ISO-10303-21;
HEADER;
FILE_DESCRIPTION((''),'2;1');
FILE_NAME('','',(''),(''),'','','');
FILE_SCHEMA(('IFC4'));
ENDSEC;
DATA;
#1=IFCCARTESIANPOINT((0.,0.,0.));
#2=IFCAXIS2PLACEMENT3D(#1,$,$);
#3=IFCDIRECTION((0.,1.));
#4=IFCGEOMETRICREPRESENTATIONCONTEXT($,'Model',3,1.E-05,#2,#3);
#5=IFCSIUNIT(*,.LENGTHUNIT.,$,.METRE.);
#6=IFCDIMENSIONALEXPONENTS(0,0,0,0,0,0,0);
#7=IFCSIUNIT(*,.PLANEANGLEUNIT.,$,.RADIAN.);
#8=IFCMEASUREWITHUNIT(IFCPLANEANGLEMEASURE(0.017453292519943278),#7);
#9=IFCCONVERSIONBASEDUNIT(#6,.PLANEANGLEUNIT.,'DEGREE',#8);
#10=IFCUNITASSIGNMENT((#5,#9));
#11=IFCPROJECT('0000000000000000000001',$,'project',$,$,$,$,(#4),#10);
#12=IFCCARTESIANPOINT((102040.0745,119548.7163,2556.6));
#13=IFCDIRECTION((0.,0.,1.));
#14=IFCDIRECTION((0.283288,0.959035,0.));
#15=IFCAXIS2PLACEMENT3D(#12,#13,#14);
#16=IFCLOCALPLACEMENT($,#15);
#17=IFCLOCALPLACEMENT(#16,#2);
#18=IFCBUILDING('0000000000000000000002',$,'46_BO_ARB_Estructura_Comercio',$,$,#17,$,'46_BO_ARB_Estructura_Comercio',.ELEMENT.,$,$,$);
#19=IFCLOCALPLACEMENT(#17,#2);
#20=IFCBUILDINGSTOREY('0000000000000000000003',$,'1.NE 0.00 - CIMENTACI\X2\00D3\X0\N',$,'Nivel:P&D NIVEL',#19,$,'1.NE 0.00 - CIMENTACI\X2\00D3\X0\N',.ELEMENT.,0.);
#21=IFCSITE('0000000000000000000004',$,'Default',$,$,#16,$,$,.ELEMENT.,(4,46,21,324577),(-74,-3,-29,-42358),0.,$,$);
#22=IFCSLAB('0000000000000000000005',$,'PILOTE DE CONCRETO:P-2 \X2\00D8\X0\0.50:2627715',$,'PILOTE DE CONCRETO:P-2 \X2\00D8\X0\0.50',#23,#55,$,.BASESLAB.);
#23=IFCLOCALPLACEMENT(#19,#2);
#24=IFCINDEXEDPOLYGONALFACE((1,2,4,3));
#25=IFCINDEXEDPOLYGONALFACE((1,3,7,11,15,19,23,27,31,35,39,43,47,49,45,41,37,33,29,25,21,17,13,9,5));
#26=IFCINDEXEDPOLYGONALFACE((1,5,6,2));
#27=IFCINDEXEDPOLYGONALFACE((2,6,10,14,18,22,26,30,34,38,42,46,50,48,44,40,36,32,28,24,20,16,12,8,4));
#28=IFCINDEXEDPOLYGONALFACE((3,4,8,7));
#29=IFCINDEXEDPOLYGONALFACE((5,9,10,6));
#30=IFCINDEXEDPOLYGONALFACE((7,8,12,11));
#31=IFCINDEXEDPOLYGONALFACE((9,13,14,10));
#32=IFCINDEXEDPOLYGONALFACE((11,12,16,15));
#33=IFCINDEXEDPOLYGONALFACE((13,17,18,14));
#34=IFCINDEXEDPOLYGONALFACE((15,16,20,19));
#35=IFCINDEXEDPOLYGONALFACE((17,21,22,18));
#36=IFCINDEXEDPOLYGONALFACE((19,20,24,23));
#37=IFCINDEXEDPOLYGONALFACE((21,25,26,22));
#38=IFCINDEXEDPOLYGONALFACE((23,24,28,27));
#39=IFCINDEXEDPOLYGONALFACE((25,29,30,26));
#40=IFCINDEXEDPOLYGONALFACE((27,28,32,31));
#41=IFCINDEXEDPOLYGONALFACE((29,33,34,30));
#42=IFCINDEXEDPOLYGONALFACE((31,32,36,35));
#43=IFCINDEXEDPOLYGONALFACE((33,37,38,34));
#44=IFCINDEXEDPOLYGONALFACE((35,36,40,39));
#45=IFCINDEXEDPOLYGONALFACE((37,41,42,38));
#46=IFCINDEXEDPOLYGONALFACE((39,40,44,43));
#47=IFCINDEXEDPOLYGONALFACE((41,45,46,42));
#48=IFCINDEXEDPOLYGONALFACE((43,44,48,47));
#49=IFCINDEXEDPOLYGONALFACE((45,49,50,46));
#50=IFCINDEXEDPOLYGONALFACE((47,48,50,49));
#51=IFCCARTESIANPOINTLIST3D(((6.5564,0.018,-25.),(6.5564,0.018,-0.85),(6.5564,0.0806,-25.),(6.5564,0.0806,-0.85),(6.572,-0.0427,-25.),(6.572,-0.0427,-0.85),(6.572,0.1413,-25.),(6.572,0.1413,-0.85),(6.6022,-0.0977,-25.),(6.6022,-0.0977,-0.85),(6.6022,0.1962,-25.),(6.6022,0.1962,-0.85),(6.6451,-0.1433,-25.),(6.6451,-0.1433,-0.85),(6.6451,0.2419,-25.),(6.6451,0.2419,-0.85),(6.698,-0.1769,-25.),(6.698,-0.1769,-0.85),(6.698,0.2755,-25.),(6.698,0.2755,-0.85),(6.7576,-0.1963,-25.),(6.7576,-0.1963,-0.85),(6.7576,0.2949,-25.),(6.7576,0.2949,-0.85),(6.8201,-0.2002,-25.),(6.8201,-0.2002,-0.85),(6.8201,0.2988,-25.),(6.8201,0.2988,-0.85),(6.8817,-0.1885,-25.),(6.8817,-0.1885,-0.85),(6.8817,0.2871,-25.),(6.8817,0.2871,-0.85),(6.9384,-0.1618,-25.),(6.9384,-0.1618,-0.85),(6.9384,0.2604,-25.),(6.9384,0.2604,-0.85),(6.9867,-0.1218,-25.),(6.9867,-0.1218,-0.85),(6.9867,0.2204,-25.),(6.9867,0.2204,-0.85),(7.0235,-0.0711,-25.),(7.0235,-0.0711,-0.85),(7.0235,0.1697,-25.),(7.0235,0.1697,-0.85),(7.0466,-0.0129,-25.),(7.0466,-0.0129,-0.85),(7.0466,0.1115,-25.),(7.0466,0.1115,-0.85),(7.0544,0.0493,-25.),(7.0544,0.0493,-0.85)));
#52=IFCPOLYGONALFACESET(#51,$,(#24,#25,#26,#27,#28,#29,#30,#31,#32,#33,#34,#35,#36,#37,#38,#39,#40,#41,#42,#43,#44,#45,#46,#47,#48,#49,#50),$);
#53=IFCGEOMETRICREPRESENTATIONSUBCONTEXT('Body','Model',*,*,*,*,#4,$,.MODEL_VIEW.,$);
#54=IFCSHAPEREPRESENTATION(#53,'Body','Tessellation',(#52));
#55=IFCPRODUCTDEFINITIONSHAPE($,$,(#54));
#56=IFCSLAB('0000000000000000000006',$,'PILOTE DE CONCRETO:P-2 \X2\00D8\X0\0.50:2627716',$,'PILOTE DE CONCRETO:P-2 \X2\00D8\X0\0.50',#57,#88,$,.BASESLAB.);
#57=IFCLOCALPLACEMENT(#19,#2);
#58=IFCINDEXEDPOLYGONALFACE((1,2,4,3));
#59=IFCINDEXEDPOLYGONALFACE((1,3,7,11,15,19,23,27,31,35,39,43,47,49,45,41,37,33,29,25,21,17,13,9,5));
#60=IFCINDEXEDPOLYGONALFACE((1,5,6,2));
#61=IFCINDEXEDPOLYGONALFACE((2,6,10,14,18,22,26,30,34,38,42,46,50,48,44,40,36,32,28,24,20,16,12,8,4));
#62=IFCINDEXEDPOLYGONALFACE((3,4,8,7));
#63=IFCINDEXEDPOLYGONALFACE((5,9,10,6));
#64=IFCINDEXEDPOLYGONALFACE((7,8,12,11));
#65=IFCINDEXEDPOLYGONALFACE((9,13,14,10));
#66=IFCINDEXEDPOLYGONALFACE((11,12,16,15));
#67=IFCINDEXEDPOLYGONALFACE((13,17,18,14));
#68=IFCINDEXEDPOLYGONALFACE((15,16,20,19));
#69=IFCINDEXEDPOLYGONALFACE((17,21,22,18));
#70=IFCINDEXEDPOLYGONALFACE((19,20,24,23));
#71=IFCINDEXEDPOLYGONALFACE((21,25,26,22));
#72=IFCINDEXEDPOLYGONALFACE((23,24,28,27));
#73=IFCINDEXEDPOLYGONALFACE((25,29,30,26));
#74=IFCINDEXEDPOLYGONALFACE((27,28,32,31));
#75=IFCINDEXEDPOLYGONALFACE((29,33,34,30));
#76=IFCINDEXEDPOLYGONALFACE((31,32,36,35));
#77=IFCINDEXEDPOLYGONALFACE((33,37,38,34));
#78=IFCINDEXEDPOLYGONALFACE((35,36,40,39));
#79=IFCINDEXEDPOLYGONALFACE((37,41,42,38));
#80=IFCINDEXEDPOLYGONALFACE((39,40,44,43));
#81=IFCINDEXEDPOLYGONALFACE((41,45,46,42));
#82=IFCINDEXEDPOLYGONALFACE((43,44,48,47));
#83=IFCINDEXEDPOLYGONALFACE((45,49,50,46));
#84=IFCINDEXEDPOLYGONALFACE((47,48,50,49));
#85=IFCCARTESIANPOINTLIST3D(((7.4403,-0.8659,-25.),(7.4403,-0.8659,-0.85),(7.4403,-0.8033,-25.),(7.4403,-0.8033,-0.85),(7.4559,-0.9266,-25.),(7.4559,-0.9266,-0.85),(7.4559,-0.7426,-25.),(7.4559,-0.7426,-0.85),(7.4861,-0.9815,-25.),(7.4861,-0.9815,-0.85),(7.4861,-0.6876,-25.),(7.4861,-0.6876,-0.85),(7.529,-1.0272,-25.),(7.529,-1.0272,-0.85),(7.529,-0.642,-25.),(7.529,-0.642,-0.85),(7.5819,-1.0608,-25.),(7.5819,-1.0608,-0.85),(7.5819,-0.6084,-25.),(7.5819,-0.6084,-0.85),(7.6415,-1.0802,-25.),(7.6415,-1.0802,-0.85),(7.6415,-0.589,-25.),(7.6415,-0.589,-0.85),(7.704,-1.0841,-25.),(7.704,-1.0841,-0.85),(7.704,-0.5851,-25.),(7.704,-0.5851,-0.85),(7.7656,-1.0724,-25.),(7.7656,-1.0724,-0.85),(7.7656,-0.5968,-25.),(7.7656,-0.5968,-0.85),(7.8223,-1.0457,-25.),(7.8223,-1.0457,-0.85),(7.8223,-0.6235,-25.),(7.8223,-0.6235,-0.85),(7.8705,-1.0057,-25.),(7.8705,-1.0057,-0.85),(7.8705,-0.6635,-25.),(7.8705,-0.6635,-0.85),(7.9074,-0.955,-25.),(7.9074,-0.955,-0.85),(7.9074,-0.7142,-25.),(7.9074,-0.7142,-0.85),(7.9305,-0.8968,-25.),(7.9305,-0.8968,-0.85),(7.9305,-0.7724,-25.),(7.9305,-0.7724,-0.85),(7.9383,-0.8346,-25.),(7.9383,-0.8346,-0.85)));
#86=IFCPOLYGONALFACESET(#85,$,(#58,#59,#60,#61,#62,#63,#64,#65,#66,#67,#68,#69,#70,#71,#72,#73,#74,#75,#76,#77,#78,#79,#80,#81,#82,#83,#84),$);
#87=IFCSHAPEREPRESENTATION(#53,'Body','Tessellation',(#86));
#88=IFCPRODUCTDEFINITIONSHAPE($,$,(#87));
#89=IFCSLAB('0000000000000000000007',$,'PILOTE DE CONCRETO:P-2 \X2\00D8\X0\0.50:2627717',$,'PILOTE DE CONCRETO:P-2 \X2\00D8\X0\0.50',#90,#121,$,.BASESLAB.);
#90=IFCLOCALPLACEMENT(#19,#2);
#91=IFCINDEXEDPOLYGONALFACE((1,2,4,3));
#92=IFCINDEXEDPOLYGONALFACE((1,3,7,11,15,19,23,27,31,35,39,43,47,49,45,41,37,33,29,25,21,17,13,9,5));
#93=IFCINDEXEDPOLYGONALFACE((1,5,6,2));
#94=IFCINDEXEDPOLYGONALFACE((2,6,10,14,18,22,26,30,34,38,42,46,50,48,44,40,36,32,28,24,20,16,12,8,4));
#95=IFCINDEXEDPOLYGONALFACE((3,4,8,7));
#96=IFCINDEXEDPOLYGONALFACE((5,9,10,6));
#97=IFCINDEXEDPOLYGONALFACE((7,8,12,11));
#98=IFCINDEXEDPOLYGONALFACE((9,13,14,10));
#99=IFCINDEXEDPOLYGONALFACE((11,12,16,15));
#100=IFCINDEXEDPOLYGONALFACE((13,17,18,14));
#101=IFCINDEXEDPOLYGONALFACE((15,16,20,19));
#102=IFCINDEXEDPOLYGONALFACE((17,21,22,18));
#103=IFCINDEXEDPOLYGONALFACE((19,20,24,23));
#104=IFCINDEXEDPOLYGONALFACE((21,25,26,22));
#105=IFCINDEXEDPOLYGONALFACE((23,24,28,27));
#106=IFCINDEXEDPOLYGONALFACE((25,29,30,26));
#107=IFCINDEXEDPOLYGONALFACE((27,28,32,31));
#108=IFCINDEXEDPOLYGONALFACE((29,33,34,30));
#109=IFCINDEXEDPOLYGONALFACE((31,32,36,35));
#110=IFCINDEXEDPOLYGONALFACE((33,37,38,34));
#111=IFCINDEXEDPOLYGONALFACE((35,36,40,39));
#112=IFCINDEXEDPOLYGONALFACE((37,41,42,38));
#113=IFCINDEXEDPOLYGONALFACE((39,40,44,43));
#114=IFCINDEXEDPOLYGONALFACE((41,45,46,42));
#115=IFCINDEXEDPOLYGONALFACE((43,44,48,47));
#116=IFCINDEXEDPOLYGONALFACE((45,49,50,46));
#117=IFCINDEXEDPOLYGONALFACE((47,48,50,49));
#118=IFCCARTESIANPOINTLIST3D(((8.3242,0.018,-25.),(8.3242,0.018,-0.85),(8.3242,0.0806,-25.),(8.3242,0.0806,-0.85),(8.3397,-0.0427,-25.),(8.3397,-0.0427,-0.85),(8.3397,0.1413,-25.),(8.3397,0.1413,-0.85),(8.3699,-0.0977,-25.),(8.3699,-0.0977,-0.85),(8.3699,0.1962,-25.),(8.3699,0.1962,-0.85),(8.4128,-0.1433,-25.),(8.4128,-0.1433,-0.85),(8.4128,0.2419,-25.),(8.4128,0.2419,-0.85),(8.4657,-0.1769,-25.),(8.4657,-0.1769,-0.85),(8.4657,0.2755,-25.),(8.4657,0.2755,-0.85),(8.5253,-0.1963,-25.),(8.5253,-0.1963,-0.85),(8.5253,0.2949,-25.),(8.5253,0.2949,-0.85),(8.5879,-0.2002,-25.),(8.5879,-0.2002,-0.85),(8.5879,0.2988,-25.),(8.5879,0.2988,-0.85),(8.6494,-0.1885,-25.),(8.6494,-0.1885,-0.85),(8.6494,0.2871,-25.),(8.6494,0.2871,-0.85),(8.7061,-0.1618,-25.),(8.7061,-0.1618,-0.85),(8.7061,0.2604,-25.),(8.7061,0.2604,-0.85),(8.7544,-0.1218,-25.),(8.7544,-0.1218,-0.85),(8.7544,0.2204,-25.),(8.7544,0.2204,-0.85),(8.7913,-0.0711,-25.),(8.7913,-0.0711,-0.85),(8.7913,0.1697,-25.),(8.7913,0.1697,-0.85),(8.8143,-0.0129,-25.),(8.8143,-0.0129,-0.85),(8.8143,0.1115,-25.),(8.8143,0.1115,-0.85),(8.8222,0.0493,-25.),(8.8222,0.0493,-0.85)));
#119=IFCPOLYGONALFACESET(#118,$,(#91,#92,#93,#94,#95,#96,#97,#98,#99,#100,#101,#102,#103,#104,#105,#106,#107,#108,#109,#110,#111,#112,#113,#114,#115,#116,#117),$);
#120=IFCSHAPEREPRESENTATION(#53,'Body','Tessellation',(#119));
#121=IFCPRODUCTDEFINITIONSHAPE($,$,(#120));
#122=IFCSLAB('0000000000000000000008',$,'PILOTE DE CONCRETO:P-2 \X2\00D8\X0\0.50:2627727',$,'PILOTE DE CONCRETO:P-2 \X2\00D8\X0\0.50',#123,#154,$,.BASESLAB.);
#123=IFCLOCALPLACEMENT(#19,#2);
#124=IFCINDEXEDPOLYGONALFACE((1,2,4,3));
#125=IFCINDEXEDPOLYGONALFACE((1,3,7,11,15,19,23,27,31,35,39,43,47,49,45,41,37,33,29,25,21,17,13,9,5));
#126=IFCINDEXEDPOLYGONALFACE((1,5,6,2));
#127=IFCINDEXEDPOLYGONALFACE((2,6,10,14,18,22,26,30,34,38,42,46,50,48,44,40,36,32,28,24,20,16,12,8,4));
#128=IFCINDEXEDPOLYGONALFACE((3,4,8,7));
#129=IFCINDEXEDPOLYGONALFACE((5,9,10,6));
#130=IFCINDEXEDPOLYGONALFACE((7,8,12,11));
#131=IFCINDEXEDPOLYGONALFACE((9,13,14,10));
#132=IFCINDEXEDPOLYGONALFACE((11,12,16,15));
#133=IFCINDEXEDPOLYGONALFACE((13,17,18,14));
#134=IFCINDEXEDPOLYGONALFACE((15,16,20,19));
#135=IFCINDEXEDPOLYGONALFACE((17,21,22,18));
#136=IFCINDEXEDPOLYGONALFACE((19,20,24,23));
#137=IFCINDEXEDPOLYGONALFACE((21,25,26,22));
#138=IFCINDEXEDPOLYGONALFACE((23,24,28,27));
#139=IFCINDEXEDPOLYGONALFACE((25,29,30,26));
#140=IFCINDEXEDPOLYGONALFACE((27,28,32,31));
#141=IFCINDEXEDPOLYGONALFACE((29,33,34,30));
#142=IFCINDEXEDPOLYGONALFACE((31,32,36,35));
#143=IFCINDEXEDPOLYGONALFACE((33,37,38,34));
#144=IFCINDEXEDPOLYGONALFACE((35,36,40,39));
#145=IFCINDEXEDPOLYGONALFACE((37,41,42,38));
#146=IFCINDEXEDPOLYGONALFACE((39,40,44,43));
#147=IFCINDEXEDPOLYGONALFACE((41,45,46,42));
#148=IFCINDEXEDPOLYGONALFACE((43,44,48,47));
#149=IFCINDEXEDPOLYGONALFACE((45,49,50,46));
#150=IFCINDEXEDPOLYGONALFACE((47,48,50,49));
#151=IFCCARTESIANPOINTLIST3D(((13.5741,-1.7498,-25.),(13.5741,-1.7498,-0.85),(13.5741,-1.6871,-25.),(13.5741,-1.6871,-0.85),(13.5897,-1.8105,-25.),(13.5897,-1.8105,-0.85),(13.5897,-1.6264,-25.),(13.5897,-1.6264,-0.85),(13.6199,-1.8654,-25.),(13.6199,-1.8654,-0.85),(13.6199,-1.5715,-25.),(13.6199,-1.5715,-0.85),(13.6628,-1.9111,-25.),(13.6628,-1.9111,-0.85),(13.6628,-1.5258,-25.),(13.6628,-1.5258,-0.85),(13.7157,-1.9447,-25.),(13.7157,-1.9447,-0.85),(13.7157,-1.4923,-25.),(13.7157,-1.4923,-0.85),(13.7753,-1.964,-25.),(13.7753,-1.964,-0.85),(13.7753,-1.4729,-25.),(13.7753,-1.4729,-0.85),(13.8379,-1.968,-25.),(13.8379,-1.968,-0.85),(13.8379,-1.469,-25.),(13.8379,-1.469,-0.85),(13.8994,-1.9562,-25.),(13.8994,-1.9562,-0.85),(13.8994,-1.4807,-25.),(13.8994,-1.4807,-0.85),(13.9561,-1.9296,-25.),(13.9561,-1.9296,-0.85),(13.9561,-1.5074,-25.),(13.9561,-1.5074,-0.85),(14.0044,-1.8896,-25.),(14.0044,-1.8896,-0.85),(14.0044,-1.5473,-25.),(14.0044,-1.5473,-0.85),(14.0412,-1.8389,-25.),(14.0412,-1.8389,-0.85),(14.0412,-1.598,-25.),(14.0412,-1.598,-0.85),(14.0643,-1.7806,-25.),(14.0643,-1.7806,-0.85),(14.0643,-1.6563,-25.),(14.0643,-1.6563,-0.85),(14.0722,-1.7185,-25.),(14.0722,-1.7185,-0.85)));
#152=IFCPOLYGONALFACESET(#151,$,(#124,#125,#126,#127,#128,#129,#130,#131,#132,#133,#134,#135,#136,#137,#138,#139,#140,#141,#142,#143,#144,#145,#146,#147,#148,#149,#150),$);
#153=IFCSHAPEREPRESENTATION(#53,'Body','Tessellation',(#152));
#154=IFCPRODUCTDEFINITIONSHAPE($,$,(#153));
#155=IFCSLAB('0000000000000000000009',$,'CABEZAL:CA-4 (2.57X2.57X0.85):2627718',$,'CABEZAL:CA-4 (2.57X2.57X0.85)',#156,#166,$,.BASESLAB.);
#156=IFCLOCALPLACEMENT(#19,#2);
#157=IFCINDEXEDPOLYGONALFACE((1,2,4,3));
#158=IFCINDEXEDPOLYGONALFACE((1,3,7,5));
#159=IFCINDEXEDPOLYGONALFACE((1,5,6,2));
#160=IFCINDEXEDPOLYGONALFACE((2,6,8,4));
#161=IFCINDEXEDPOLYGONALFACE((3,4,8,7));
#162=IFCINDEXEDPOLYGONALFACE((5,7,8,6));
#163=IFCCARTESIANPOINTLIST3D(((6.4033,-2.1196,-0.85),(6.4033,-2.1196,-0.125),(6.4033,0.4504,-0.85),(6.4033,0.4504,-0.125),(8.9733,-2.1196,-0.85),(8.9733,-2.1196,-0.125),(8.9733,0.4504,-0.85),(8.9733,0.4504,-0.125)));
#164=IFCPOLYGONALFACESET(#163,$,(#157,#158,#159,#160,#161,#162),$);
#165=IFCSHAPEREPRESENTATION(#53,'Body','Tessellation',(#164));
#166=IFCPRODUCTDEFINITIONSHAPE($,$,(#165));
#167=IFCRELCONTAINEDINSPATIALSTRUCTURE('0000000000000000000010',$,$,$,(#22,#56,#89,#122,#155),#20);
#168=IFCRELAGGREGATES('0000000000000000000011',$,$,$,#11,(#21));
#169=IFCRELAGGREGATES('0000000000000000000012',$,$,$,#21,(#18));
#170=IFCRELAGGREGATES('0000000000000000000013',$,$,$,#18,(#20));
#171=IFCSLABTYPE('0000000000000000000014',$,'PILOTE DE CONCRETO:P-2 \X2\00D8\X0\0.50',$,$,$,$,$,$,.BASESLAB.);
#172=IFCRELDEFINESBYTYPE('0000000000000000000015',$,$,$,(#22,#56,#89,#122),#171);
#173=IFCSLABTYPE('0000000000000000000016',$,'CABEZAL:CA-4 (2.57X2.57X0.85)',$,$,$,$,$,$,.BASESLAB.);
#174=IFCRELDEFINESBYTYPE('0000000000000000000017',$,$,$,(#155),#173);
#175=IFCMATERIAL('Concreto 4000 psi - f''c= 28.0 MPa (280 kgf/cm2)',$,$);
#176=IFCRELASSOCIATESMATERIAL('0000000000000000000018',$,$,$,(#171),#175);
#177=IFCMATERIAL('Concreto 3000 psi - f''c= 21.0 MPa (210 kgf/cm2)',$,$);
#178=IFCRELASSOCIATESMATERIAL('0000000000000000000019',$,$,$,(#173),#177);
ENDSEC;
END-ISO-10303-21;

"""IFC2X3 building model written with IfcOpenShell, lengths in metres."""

from ifc_helpers import new_model, entity, si_unit, converted_unit, direction, frame, frame_2d, origin, place, context, subcontext, project, spatial, rectangle, circle, extrude, material, type_object, element, save


model = new_model("IFC2X3")

# Units and contexts
model_context = context("Model", 3, precision=1e-05, world=origin(), true_north=direction((0.0, 1.0)))
body_context = subcontext(model_context, "Body", "Model", "MODEL_VIEW")
ifc_project = project(units=[si_unit("LENGTHUNIT", "METRE"), converted_unit("PLANEANGLEUNIT", "DEGREE", entity("IfcPlaneAngleMeasure", 0.017453292519943278), si_unit("PLANEANGLEUNIT", "RADIAN"), dimensions=[0, 0, 0, 0, 0, 0, 0])], contexts=[model_context])

# Site, building, storey
site_placement = place(None, frame((102040.0745, 119548.7163, 2556.6), z_axis=(0.0, 0.0, 1.0), x_axis=(0.283288, 0.959035, 0.0)))
site = spatial("IfcSite", under=ifc_project, at=site_placement, Name="Default", CompositionType="ELEMENT", RefLatitude=(4, 46, 21, 324577), RefLongitude=(-74, -3, -29, -42358), RefElevation=0.0)
building_placement = place(site_placement, origin())
building = spatial("IfcBuilding", under=site, at=building_placement, Name="46_BO_ARB_Estructura_Comercio", LongName="46_BO_ARB_Estructura_Comercio", CompositionType="ELEMENT")
storey_placement = place(building_placement, origin())
storey = spatial("IfcBuildingStorey", under=building, at=storey_placement, Name="1.NE 0.00 - CIMENTACIÓN", ObjectType="Nivel:P&D NIVEL", LongName="1.NE 0.00 - CIMENTACIÓN", CompositionType="ELEMENT", Elevation=0.0)

# Shared definitions
ifc_material_1 = material(Name="Concreto 4000 psi - f'c= 28.0 MPa (280 kgf/cm2)")

# Shared definitions
ifc_material_2 = material(Name="Concreto 3000 psi - f'c= 21.0 MPa (210 kgf/cm2)")

# Slabs
slab_type_1 = type_object("IfcSlabType", Name="PILOTE DE CONCRETO:P-2 Ø0.50", PredefinedType="BASESLAB", material=ifc_material_1)
slab_1_placement = place(storey_placement, origin())
element("IfcSlab", 1, at=slab_1_placement, inside=storey, type_object=slab_type_1, Name="PILOTE DE CONCRETO:P-2 Ø0.50:2627715", ObjectType="PILOTE DE CONCRETO:P-2 Ø0.50", PredefinedType="BASESLAB", context=body_context, shape_type="SweptSolid", body=[
    extrude(circle(Radius=0.25, at=frame_2d((0.0, 0.0), x_axis=(1.0, 0.0))), frame((6.8044, 0.0493, -25.0)), (0.0, 0.0, 1.0), 24.15),
])
slab_2_placement = place(storey_placement, origin())
element("IfcSlab", 2, at=slab_2_placement, inside=storey, type_object=slab_type_1, Name="PILOTE DE CONCRETO:P-2 Ø0.50:2627716", ObjectType="PILOTE DE CONCRETO:P-2 Ø0.50", PredefinedType="BASESLAB", context=body_context, shape_type="SweptSolid", body=[
    extrude(circle(Radius=0.25, at=frame_2d((0.0, 0.0), x_axis=(1.0, 0.0))), frame((7.6883, -0.8346, -25.0)), (0.0, 0.0, 1.0), 24.15),
])
slab_3_placement = place(storey_placement, origin())
element("IfcSlab", 3, at=slab_3_placement, inside=storey, type_object=slab_type_1, Name="PILOTE DE CONCRETO:P-2 Ø0.50:2627717", ObjectType="PILOTE DE CONCRETO:P-2 Ø0.50", PredefinedType="BASESLAB", context=body_context, shape_type="SweptSolid", body=[
    extrude(circle(Radius=0.25, at=frame_2d((0.0, 0.0), x_axis=(1.0, 0.0))), frame((8.5722, 0.0493, -25.0)), (0.0, 0.0, 1.0), 24.15),
])
slab_4_placement = place(storey_placement, origin())
element("IfcSlab", 4, at=slab_4_placement, inside=storey, type_object=slab_type_1, Name="PILOTE DE CONCRETO:P-2 Ø0.50:2627727", ObjectType="PILOTE DE CONCRETO:P-2 Ø0.50", PredefinedType="BASESLAB", context=body_context, shape_type="SweptSolid", body=[
    extrude(circle(Radius=0.25, at=frame_2d((0.0, 0.0), x_axis=(1.0, 0.0))), frame((13.8222, -1.7185, -25.0)), (0.0, 0.0, 1.0), 24.15),
])
slab_type_2 = type_object("IfcSlabType", Name="CABEZAL:CA-4 (2.57X2.57X0.85)", PredefinedType="BASESLAB", material=ifc_material_2)
slab_5_placement = place(storey_placement, origin())
element("IfcSlab", 5, at=slab_5_placement, inside=storey, type_object=slab_type_2, Name="CABEZAL:CA-4 (2.57X2.57X0.85):2627718", ObjectType="CABEZAL:CA-4 (2.57X2.57X0.85)", PredefinedType="BASESLAB", context=body_context, shape_type="SweptSolid", body=[
    extrude(rectangle(XDim=2.57, YDim=2.57, at=frame_2d((0.0, 0.0), x_axis=(1.0, 0.0))), frame((7.6883, -0.8346, -0.85), z_axis=(0.0, 0.0, 1.0), x_axis=(-1.0, 0.0, 0.0)), (0.0, 0.0, 1.0), 0.725),
])

save(model, "model.ifc")
